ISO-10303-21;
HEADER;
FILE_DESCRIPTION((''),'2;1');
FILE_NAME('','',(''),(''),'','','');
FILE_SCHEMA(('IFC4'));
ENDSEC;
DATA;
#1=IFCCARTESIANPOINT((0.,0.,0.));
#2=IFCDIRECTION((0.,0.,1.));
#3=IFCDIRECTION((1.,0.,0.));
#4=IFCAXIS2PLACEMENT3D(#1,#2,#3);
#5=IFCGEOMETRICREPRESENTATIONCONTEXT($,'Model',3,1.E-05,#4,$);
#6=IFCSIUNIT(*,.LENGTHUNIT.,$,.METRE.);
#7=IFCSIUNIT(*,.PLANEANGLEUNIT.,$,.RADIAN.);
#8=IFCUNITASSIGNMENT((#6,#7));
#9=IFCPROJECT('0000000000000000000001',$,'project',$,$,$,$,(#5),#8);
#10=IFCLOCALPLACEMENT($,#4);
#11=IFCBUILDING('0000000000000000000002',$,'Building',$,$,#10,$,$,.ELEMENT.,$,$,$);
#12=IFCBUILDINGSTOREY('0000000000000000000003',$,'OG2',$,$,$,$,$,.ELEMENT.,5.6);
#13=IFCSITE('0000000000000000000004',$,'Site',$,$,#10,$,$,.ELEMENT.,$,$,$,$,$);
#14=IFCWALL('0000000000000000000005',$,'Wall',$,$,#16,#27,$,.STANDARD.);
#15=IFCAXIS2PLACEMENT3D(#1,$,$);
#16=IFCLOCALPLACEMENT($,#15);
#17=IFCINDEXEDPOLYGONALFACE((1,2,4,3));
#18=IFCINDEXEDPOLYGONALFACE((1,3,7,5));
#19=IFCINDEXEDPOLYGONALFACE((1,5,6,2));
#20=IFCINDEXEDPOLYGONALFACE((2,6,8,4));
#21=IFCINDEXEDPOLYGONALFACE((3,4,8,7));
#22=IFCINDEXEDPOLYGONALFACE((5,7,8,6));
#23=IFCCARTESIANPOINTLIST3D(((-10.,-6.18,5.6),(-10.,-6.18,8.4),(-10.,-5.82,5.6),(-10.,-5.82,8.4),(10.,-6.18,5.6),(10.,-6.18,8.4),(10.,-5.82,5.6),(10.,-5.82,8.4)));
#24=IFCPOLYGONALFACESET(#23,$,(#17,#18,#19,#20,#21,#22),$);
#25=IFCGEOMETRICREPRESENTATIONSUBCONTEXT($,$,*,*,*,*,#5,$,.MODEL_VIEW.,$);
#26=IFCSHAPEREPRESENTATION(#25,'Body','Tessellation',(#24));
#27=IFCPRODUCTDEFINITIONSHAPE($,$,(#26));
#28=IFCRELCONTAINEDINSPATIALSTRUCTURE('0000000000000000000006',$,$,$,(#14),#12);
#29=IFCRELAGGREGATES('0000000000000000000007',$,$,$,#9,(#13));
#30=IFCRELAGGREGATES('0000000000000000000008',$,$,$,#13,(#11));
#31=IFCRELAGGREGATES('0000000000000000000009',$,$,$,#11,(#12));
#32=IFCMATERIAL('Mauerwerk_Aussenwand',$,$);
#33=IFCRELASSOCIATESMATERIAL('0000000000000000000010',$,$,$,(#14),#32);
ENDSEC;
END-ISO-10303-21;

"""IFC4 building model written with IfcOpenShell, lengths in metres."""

from ifc_helpers import new_model, si_unit, frame, frame_2d, origin, origin_with_axes, place, context, subcontext, project, spatial, rectangle, extrude, material, element, save


model = new_model("IFC4")

# Units and contexts
model_context = context("Model", 3, precision=1e-05, world=origin_with_axes())
sub_context = subcontext(model_context, None, None, "MODEL_VIEW")
ifc_project = project(units=[si_unit("LENGTHUNIT", "METRE"), si_unit("PLANEANGLEUNIT", "RADIAN")], contexts=[model_context])

# Site, building, storey
placement_1 = place(None, origin_with_axes())
site = spatial("IfcSite", under=ifc_project, at=placement_1, Name="Site", CompositionType="ELEMENT")
building = spatial("IfcBuilding", under=site, at=placement_1, Name="Building", CompositionType="ELEMENT")
storey = spatial("IfcBuildingStorey", under=building, Name="OG2", CompositionType="ELEMENT", Elevation=5.6)

# Wall
ifc_material = material(Name="Mauerwerk_Aussenwand")
placement_2 = place(None, origin_with_axes())
placement_3 = place(placement_2, frame((0.0, 0.0, 5.6)))
wall_placement = place(placement_3, frame((-10.0, -6.0, 0.0), x_axis=(1.0, 0.0, 0.0)))
element("IfcWall", 1, at=wall_placement, inside=storey, material=ifc_material, Name="Wall", PredefinedType="STANDARD", context=sub_context, shape_type="SweptSolid", body=[
    extrude(rectangle(XDim=20.0, YDim=0.36, at=frame_2d((10.0, 0.0))), origin(), (0.0, 0.0, 1.0), 2.8),
])

save(model, "model.ifc")
